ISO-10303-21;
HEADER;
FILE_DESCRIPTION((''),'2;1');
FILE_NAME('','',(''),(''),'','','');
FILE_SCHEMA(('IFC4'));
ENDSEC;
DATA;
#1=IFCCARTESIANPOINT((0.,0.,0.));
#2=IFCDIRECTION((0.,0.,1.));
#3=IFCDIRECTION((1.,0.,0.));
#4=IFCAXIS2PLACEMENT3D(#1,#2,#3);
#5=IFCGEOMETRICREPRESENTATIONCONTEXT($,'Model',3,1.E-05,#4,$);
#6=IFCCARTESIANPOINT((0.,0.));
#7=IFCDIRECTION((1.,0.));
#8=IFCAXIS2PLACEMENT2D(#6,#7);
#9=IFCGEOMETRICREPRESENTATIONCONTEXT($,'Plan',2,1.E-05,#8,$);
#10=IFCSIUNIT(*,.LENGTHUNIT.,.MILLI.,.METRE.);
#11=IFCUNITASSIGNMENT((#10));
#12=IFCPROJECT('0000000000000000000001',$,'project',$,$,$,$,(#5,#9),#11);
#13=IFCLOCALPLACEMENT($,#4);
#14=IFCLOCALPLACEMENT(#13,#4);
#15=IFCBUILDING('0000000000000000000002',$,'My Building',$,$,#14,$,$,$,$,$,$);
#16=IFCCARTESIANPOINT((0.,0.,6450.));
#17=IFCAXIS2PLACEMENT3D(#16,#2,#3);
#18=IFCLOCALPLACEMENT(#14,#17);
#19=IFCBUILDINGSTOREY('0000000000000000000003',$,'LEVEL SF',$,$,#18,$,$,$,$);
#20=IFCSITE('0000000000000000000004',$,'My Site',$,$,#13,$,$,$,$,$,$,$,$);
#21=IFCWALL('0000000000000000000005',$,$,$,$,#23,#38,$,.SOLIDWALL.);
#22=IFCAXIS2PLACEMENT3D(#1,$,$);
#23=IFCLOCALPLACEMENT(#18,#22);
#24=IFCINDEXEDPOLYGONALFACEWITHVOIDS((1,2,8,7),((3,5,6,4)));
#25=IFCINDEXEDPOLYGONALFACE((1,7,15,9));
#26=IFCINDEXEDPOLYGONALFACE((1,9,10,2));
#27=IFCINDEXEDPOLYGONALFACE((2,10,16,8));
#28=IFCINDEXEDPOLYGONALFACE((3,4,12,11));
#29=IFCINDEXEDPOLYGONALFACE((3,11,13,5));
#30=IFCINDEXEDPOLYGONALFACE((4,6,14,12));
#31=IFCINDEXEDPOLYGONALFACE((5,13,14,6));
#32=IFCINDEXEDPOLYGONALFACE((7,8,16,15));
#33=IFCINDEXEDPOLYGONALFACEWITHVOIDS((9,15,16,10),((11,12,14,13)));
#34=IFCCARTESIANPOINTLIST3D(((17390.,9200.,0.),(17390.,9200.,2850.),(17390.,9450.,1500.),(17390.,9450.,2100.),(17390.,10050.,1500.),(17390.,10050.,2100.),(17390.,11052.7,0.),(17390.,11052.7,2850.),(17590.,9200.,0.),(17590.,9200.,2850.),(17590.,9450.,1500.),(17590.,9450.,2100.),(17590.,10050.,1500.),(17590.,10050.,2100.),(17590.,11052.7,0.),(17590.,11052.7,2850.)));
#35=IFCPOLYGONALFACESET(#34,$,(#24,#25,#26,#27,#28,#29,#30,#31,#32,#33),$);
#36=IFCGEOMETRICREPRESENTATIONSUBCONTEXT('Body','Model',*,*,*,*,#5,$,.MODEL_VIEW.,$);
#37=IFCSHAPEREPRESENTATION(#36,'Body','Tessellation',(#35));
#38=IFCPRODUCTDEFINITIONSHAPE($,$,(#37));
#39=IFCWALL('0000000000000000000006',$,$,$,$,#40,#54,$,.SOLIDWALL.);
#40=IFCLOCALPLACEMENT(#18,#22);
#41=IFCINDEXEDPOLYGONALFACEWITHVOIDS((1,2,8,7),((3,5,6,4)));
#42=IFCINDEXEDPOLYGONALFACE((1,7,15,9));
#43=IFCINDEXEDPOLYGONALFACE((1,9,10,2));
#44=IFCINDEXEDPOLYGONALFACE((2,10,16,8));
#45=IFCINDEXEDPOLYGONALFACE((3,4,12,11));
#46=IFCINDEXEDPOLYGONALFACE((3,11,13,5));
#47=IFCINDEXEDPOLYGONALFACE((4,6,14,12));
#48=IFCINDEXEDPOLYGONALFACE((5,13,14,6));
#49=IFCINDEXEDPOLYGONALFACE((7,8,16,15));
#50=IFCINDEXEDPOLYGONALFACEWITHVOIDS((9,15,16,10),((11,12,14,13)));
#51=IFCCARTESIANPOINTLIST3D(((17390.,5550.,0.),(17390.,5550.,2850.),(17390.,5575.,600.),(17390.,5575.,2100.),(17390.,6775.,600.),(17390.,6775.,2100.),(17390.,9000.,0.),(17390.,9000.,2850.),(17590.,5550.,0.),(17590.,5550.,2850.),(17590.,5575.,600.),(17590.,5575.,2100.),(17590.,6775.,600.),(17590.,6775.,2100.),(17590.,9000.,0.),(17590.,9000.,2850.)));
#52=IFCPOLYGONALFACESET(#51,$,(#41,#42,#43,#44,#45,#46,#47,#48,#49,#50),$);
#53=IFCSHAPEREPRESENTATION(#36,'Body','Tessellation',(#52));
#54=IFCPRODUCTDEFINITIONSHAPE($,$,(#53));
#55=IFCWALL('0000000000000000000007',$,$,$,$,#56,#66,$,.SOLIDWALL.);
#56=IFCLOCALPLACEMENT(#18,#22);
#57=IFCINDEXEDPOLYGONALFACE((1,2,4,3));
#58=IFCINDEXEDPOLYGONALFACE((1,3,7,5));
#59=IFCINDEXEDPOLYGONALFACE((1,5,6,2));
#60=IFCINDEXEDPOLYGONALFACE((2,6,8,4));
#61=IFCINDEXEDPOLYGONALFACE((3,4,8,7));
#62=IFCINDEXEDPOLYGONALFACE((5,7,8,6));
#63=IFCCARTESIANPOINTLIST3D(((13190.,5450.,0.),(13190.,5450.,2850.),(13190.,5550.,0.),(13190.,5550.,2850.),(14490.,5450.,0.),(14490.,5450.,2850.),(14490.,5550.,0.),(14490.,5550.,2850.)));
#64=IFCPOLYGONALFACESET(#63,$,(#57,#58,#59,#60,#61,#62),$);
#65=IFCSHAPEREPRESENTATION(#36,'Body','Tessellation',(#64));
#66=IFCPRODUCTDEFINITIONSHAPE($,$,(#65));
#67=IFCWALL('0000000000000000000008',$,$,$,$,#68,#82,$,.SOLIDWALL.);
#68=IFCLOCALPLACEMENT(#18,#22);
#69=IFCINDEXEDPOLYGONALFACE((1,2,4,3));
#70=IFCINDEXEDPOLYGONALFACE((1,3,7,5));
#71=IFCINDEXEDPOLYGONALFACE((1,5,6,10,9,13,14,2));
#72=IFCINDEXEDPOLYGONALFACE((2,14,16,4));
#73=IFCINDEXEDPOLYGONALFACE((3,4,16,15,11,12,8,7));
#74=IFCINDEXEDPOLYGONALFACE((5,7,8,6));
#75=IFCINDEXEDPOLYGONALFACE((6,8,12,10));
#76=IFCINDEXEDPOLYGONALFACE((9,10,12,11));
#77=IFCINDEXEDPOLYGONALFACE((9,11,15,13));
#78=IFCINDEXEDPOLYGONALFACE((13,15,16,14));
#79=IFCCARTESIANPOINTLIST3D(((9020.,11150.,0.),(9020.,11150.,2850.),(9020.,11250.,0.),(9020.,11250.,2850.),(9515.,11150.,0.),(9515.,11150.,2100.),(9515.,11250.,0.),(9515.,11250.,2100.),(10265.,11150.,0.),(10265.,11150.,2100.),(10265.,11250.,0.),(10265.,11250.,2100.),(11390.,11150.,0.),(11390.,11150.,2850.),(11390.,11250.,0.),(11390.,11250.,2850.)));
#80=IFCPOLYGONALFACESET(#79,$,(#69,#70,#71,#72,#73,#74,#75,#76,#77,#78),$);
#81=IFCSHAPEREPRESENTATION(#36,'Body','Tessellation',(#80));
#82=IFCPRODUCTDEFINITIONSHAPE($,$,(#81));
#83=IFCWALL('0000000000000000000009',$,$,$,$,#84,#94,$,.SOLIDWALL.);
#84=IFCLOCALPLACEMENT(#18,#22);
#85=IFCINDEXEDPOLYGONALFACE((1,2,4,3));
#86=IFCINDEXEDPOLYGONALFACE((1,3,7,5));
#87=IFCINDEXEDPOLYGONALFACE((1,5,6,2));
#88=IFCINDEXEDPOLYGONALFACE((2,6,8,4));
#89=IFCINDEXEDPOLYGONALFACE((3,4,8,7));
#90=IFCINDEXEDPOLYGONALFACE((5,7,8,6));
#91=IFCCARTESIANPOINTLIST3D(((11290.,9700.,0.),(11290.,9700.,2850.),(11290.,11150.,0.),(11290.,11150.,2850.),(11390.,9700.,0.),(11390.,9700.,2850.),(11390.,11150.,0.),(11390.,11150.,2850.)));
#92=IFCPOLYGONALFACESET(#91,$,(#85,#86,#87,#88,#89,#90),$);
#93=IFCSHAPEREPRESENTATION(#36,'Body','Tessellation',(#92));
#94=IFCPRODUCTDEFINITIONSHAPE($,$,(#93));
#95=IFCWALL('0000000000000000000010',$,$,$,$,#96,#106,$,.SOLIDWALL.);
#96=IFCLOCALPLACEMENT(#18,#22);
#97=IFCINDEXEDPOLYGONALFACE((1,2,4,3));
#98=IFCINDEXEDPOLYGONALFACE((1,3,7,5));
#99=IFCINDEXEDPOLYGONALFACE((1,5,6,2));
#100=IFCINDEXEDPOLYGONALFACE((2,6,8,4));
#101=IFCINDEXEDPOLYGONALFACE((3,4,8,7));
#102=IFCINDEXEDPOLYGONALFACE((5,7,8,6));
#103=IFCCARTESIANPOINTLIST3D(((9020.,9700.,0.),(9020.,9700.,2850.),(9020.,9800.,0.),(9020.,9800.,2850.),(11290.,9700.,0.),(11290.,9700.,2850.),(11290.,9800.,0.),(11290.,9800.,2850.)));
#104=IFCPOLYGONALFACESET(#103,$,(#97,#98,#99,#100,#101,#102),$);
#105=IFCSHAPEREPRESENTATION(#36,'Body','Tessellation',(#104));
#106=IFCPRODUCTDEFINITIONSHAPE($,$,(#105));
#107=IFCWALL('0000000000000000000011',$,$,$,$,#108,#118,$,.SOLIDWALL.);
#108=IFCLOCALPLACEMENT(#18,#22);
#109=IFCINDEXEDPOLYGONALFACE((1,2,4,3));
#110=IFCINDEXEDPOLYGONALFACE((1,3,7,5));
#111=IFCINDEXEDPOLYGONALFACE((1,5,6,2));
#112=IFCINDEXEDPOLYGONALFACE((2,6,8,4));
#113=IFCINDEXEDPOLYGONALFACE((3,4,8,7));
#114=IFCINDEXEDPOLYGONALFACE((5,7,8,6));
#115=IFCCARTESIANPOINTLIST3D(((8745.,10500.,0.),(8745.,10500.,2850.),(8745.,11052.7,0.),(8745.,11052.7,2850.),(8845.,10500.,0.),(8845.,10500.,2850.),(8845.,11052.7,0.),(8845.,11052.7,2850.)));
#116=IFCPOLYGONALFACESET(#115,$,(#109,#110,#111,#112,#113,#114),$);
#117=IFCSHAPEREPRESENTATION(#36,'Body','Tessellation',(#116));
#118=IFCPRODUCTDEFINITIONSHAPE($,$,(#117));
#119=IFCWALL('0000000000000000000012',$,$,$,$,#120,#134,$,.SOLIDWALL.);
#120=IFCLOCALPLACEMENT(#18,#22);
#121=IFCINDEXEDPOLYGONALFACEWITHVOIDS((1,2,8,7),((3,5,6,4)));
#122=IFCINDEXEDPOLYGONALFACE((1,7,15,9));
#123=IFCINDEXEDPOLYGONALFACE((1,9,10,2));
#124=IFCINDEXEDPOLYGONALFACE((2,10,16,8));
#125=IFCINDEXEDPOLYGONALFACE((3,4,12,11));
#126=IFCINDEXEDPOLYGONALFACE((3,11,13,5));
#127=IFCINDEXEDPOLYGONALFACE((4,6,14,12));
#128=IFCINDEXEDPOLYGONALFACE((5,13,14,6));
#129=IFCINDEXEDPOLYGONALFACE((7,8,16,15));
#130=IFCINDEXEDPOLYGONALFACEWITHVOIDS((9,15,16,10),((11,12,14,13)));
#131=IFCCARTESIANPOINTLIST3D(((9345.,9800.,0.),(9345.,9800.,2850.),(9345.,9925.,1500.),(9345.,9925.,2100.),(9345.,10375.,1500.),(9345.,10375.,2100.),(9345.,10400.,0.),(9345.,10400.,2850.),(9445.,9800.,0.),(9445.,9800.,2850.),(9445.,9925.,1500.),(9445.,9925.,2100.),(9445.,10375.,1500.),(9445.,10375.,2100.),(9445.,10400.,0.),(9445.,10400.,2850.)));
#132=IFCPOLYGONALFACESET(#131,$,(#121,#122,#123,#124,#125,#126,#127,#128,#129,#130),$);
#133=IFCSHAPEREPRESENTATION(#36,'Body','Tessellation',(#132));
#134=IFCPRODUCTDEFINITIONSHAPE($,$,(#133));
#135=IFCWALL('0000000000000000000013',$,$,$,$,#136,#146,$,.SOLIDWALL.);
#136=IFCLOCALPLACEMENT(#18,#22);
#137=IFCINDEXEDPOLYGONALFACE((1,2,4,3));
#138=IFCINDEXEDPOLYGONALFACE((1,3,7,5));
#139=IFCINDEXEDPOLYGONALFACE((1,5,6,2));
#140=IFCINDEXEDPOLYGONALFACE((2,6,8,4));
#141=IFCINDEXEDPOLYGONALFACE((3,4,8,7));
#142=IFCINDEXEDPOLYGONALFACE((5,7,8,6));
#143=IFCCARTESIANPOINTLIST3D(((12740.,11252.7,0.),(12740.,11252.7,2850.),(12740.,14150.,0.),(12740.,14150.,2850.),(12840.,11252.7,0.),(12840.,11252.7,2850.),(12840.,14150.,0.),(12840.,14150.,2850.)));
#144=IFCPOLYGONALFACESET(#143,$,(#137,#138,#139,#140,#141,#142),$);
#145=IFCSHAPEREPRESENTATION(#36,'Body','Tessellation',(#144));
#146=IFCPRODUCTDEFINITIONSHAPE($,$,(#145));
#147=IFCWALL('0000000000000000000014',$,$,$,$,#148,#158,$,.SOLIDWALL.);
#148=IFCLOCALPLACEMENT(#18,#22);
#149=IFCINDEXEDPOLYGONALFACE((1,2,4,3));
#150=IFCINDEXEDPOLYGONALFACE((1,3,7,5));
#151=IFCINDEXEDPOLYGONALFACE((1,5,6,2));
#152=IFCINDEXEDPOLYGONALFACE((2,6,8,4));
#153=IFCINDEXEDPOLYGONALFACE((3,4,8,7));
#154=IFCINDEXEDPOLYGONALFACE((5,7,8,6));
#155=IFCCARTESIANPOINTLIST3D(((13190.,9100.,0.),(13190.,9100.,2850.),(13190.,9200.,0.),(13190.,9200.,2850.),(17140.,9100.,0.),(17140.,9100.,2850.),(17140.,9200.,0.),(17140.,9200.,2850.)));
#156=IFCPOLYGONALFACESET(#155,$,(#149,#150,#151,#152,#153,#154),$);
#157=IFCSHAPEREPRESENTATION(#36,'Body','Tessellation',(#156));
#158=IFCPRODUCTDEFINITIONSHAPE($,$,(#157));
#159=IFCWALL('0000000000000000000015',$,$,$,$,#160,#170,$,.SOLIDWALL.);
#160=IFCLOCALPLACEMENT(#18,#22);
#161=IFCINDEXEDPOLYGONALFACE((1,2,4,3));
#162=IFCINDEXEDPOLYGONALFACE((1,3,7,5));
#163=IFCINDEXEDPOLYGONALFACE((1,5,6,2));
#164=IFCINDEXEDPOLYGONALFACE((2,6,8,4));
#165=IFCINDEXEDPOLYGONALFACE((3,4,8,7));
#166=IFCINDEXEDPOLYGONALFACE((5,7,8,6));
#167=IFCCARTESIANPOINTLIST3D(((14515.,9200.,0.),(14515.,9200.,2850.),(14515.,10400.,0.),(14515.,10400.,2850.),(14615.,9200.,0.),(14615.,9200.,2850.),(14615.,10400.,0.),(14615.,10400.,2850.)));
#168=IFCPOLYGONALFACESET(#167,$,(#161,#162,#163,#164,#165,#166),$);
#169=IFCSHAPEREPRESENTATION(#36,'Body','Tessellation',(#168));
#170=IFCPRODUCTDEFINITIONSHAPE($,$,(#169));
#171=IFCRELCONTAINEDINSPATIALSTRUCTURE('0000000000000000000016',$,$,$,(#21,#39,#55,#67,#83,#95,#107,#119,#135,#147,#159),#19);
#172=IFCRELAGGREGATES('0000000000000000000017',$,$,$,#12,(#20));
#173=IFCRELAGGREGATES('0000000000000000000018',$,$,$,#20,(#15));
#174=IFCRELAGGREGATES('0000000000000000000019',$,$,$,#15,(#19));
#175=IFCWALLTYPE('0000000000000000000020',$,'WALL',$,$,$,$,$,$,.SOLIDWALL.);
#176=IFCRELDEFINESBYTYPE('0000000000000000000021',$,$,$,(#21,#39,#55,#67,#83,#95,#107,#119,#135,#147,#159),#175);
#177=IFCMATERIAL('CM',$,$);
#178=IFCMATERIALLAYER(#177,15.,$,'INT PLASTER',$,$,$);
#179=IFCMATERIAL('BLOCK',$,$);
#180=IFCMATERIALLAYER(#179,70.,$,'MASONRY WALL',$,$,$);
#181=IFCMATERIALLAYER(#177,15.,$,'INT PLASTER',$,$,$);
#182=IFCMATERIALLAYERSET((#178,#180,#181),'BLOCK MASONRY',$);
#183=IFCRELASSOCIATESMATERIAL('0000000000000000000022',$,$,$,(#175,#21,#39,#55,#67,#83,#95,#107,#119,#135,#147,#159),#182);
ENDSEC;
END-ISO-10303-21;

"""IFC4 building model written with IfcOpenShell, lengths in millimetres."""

from ifc_helpers import new_model, si_unit, frame, origin_with_axes, origin_2d_with_axis, place, context, subcontext, project, spatial, indexed_curve, outline, extrude, material, layer, layer_set, layer_usage, type_object, element, save


model = new_model("IFC4")

# Units and contexts
model_context = context("Model", 3, precision=1e-05, world=origin_with_axes())
plan_context = context("Plan", 2, precision=1e-05, world=origin_2d_with_axis())
body_context = subcontext(model_context, "Body", "Model", "MODEL_VIEW")
ifc_project = project(units=[si_unit("LENGTHUNIT", "METRE", prefix="MILLI")], contexts=[model_context, plan_context])

# Site, building, storey
site_placement = place(None, origin_with_axes())
site = spatial("IfcSite", under=ifc_project, at=site_placement, Name="My Site")
building_placement = place(site_placement, origin_with_axes())
building = spatial("IfcBuilding", under=site, at=building_placement, Name="My Building")
storey_placement = place(building_placement, frame((0.0, 0.0, 6450.0), z_axis=(0.0, 0.0, 1.0), x_axis=(1.0, 0.0, 0.0)))
storey = spatial("IfcBuildingStorey", under=building, at=storey_placement, Name="LEVEL SF")

# Shared definitions
ifc_material_1 = material(Name="CM")
ifc_layer_1 = layer(ifc_material_1, 15.0, Name="INT PLASTER")
ifc_material_2 = material(Name="BLOCK")
ifc_layer_2 = layer(ifc_material_2, 70.0, Name="MASONRY WALL")
ifc_layer_3 = layer(ifc_material_1, 15.0, Name="INT PLASTER")
ifc_layer_set = layer_set([ifc_layer_1, ifc_layer_2, ifc_layer_3], Name="BLOCK MASONRY")
wall_type = type_object("IfcWallType", Name="WALL", PredefinedType="SOLIDWALL", material=ifc_layer_set)

# Walls, openings
ifc_layer_usage_1 = layer_usage(ifc_layer_set, "AXIS2", "POSITIVE", 0.0)
wall_1_placement = place(storey_placement, frame((17590.0, 9200.0, 0.0), z_axis=(0.0, 0.0, 1.0), x_axis=(0.0, 1.0, 0.0)))
wall_1 = element("IfcWall", 1, at=wall_1_placement, inside=storey, type_object=wall_type, material=ifc_layer_usage_1, PredefinedType="SOLIDWALL", context=body_context, shape_type="SweptSolid", body=[
    extrude(outline(indexed_curve([(0.0, 0.0), (0.0, 200.0), (1852.7, 200.0), (1852.7, 0.0), (0.0, 0.0)], self_intersect=False)), origin_with_axes(), (0.0, 0.0, 1.0), 2850.0),
])
opening_1_placement = place(wall_1_placement, frame((850.0, 200.0, 1500.0), z_axis=(0.0, 0.0, 1.0), x_axis=(-1.0, 0.0, 0.0)))
element("IfcOpeningElement", 2, at=opening_1_placement, cuts=wall_1, PredefinedType="OPENING", context=body_context, shape_type="SweptSolid", body=[
    extrude(outline(indexed_curve([(0.0, 0.0), (0.0, 400.0), (600.0, 400.0), (600.0, 0.0), (0.0, 0.0)], self_intersect=False)), frame((0.0, -100.0, 0.0), z_axis=(0.0, 0.0, 1.0), x_axis=(1.0, 0.0, 0.0)), (0.0, 0.0, 1.0), 600.0),
])
ifc_layer_usage_2 = layer_usage(ifc_layer_set, "AXIS2", "POSITIVE", 0.0)
wall_2_placement = place(storey_placement, frame((17590.0, 5550.0, 0.0), z_axis=(0.0, 0.0, 1.0), x_axis=(0.0, 1.0, 0.0)))
wall_2 = element("IfcWall", 3, at=wall_2_placement, inside=storey, type_object=wall_type, material=ifc_layer_usage_2, PredefinedType="SOLIDWALL", context=body_context, shape_type="SweptSolid", body=[
    extrude(outline(indexed_curve([(0.0, 0.0), (0.0, 200.0), (3450.0, 200.0), (3450.0, 0.0), (0.0, 0.0)], self_intersect=False)), origin_with_axes(), (0.0, 0.0, 1.0), 2850.0),
])
opening_2_placement = place(wall_2_placement, frame((1225.0, 200.0, 600.0), z_axis=(0.0, 0.0, 1.0), x_axis=(-1.0, 0.0, 0.0)))
element("IfcOpeningElement", 4, at=opening_2_placement, cuts=wall_2, PredefinedType="OPENING", context=body_context, shape_type="SweptSolid", body=[
    extrude(outline(indexed_curve([(0.0, 0.0), (0.0, 400.0), (1200.0, 400.0), (1200.0, 0.0), (0.0, 0.0)], self_intersect=False)), frame((0.0, -100.0, 0.0), z_axis=(0.0, 0.0, 1.0), x_axis=(1.0, 0.0, 0.0)), (0.0, 0.0, 1.0), 1500.0),
])

# Wall
ifc_layer_usage_3 = layer_usage(ifc_layer_set, "AXIS2", "POSITIVE", 0.0)
wall_3_placement = place(storey_placement, frame((13190.0, 5550.0, 0.0), z_axis=(0.0, 0.0, 1.0), x_axis=(0.0, -1.0, 0.0)))
element("IfcWall", 5, at=wall_3_placement, inside=storey, type_object=wall_type, material=ifc_layer_usage_3, PredefinedType="SOLIDWALL", context=body_context, shape_type="SweptSolid", body=[
    extrude(outline(indexed_curve([(0.0, 0.0), (0.0, 1300.0), (100.0, 1300.0), (100.0, 0.0), (0.0, 0.0)], self_intersect=False)), origin_with_axes(), (0.0, 0.0, 1.0), 2850.0),
])

# Wall, opening
ifc_layer_usage_4 = layer_usage(ifc_layer_set, "AXIS2", "POSITIVE", 0.0)
wall_4_placement = place(storey_placement, frame((9020.0, 11250.0, 0.0), z_axis=(0.0, 0.0, 1.0), x_axis=(0.0, -1.0, 0.0)))
wall_4 = element("IfcWall", 6, at=wall_4_placement, inside=storey, type_object=wall_type, material=ifc_layer_usage_4, PredefinedType="SOLIDWALL", context=body_context, shape_type="SweptSolid", body=[
    extrude(outline(indexed_curve([(0.0, 0.0), (0.0, 2370.0), (100.0, 2370.0), (100.0, 0.0), (0.0, 0.0)], self_intersect=False)), origin_with_axes(), (0.0, 0.0, 1.0), 2850.0),
])
opening_3_placement = place(wall_4_placement, frame((0.0, 1245.0, 0.0), z_axis=(0.0, 0.0, 1.0), x_axis=(0.0, -1.0, 0.0)))
element("IfcOpeningElement", 7, at=opening_3_placement, cuts=wall_4, PredefinedType="OPENING", context=body_context, shape_type="SweptSolid", body=[
    extrude(outline(indexed_curve([(0.0, 0.0), (0.0, 400.0), (750.0, 400.0), (750.0, 0.0), (0.0, 0.0)], self_intersect=False)), frame((0.0, -100.0, 0.0), z_axis=(0.0, 0.0, 1.0), x_axis=(1.0, 0.0, 0.0)), (0.0, 0.0, 1.0), 2100.0),
])

# Walls
ifc_layer_usage_5 = layer_usage(ifc_layer_set, "AXIS2", "POSITIVE", 0.0)
wall_5_placement = place(storey_placement, frame((11390.0, 9700.0, 0.0), z_axis=(0.0, 0.0, 1.0), x_axis=(0.0, 1.0, 0.0)))
element("IfcWall", 8, at=wall_5_placement, inside=storey, type_object=wall_type, material=ifc_layer_usage_5, PredefinedType="SOLIDWALL", context=body_context, shape_type="SweptSolid", body=[
    extrude(outline(indexed_curve([(0.0, 0.0), (0.0, 100.0), (1450.0, 100.0), (1450.0, 0.0), (0.0, 0.0)], self_intersect=False)), origin_with_axes(), (0.0, 0.0, 1.0), 2850.0),
])
ifc_layer_usage_6 = layer_usage(ifc_layer_set, "AXIS2", "POSITIVE", 0.0)
wall_6_placement = place(storey_placement, frame((9020.0, 9800.0, 0.0), z_axis=(0.0, 0.0, 1.0), x_axis=(0.0, -1.0, 0.0)))
element("IfcWall", 9, at=wall_6_placement, inside=storey, type_object=wall_type, material=ifc_layer_usage_6, PredefinedType="SOLIDWALL", context=body_context, shape_type="SweptSolid", body=[
    extrude(outline(indexed_curve([(0.0, 0.0), (0.0, 2270.0), (100.0, 2270.0), (100.0, 0.0), (0.0, 0.0)], self_intersect=False)), origin_with_axes(), (0.0, 0.0, 1.0), 2850.0),
])

# Wall
ifc_layer_usage_7 = layer_usage(ifc_layer_set, "AXIS2", "POSITIVE", 0.0)
wall_7_placement = place(storey_placement, frame((8845.0, 10500.0, 0.0), z_axis=(0.0, 0.0, 1.0), x_axis=(0.0, 1.0, 0.0)))
element("IfcWall", 10, at=wall_7_placement, inside=storey, type_object=wall_type, material=ifc_layer_usage_7, PredefinedType="SOLIDWALL", context=body_context, shape_type="SweptSolid", body=[
    extrude(outline(indexed_curve([(0.0, 0.0), (0.0, 100.0), (552.7, 100.0), (552.7, 0.0), (0.0, 0.0)], self_intersect=False)), origin_with_axes(), (0.0, 0.0, 1.0), 2850.0),
])

# Wall, opening
ifc_layer_usage_8 = layer_usage(ifc_layer_set, "AXIS2", "POSITIVE", 0.0)
wall_8_placement = place(storey_placement, frame((9445.0, 9800.0, 0.0), z_axis=(0.0, 0.0, 1.0), x_axis=(0.0, 1.0, 0.0)))
wall_8 = element("IfcWall", 11, at=wall_8_placement, inside=storey, type_object=wall_type, material=ifc_layer_usage_8, PredefinedType="SOLIDWALL", context=body_context, shape_type="SweptSolid", body=[
    extrude(outline(indexed_curve([(0.0, 0.0), (0.0, 100.0), (600.0, 100.0), (600.0, 0.0), (0.0, 0.0)], self_intersect=False)), origin_with_axes(), (0.0, 0.0, 1.0), 2850.0),
])
opening_4_placement = place(wall_8_placement, frame((125.0, 0.0, 1500.0), z_axis=(0.0, 0.0, 1.0), x_axis=(1.0, 0.0, 0.0)))
element("IfcOpeningElement", 12, at=opening_4_placement, cuts=wall_8, PredefinedType="OPENING", context=body_context, shape_type="SweptSolid", body=[
    extrude(outline(indexed_curve([(0.0, 0.0), (0.0, 400.0), (450.0, 400.0), (450.0, 0.0), (0.0, 0.0)], self_intersect=False)), frame((0.0, -100.0, 0.0), z_axis=(0.0, 0.0, 1.0), x_axis=(1.0, 0.0, 0.0)), (0.0, 0.0, 1.0), 600.0),
])

# Walls
ifc_layer_usage_9 = layer_usage(ifc_layer_set, "AXIS2", "POSITIVE", 0.0)
wall_9_placement = place(storey_placement, frame((12840.0, 11252.7, 0.0), z_axis=(0.0, 0.0, 1.0), x_axis=(0.0, 1.0, 0.0)))
element("IfcWall", 13, at=wall_9_placement, inside=storey, type_object=wall_type, material=ifc_layer_usage_9, PredefinedType="SOLIDWALL", context=body_context, shape_type="SweptSolid", body=[
    extrude(outline(indexed_curve([(0.0, 0.0), (0.0, 100.0), (2897.3, 100.0), (2897.3, 0.0), (0.0, 0.0)], self_intersect=False)), origin_with_axes(), (0.0, 0.0, 1.0), 2850.0),
])
ifc_layer_usage_10 = layer_usage(ifc_layer_set, "AXIS2", "POSITIVE", 0.0)
wall_10_placement = place(storey_placement, frame((13190.0, 9200.0, 0.0), z_axis=(0.0, 0.0, 1.0), x_axis=(0.0, -1.0, 0.0)))
element("IfcWall", 14, at=wall_10_placement, inside=storey, type_object=wall_type, material=ifc_layer_usage_10, PredefinedType="SOLIDWALL", context=body_context, shape_type="SweptSolid", body=[
    extrude(outline(indexed_curve([(0.0, 0.0), (0.0, 3950.0), (100.0, 3950.0), (100.0, 0.0), (0.0, 0.0)], self_intersect=False)), origin_with_axes(), (0.0, 0.0, 1.0), 2850.0),
])
ifc_layer_usage_11 = layer_usage(ifc_layer_set, "AXIS2", "POSITIVE", 0.0)
wall_11_placement = place(storey_placement, frame((14615.0, 9200.0, 0.0), z_axis=(0.0, 0.0, 1.0), x_axis=(0.0, 1.0, 0.0)))
element("IfcWall", 15, at=wall_11_placement, inside=storey, type_object=wall_type, material=ifc_layer_usage_11, PredefinedType="SOLIDWALL", context=body_context, shape_type="SweptSolid", body=[
    extrude(outline(indexed_curve([(0.0, 0.0), (0.0, 100.0), (1200.0, 100.0), (1200.0, 0.0), (0.0, 0.0)], self_intersect=False)), origin_with_axes(), (0.0, 0.0, 1.0), 2850.0),
])

save(model, "model.ifc")
